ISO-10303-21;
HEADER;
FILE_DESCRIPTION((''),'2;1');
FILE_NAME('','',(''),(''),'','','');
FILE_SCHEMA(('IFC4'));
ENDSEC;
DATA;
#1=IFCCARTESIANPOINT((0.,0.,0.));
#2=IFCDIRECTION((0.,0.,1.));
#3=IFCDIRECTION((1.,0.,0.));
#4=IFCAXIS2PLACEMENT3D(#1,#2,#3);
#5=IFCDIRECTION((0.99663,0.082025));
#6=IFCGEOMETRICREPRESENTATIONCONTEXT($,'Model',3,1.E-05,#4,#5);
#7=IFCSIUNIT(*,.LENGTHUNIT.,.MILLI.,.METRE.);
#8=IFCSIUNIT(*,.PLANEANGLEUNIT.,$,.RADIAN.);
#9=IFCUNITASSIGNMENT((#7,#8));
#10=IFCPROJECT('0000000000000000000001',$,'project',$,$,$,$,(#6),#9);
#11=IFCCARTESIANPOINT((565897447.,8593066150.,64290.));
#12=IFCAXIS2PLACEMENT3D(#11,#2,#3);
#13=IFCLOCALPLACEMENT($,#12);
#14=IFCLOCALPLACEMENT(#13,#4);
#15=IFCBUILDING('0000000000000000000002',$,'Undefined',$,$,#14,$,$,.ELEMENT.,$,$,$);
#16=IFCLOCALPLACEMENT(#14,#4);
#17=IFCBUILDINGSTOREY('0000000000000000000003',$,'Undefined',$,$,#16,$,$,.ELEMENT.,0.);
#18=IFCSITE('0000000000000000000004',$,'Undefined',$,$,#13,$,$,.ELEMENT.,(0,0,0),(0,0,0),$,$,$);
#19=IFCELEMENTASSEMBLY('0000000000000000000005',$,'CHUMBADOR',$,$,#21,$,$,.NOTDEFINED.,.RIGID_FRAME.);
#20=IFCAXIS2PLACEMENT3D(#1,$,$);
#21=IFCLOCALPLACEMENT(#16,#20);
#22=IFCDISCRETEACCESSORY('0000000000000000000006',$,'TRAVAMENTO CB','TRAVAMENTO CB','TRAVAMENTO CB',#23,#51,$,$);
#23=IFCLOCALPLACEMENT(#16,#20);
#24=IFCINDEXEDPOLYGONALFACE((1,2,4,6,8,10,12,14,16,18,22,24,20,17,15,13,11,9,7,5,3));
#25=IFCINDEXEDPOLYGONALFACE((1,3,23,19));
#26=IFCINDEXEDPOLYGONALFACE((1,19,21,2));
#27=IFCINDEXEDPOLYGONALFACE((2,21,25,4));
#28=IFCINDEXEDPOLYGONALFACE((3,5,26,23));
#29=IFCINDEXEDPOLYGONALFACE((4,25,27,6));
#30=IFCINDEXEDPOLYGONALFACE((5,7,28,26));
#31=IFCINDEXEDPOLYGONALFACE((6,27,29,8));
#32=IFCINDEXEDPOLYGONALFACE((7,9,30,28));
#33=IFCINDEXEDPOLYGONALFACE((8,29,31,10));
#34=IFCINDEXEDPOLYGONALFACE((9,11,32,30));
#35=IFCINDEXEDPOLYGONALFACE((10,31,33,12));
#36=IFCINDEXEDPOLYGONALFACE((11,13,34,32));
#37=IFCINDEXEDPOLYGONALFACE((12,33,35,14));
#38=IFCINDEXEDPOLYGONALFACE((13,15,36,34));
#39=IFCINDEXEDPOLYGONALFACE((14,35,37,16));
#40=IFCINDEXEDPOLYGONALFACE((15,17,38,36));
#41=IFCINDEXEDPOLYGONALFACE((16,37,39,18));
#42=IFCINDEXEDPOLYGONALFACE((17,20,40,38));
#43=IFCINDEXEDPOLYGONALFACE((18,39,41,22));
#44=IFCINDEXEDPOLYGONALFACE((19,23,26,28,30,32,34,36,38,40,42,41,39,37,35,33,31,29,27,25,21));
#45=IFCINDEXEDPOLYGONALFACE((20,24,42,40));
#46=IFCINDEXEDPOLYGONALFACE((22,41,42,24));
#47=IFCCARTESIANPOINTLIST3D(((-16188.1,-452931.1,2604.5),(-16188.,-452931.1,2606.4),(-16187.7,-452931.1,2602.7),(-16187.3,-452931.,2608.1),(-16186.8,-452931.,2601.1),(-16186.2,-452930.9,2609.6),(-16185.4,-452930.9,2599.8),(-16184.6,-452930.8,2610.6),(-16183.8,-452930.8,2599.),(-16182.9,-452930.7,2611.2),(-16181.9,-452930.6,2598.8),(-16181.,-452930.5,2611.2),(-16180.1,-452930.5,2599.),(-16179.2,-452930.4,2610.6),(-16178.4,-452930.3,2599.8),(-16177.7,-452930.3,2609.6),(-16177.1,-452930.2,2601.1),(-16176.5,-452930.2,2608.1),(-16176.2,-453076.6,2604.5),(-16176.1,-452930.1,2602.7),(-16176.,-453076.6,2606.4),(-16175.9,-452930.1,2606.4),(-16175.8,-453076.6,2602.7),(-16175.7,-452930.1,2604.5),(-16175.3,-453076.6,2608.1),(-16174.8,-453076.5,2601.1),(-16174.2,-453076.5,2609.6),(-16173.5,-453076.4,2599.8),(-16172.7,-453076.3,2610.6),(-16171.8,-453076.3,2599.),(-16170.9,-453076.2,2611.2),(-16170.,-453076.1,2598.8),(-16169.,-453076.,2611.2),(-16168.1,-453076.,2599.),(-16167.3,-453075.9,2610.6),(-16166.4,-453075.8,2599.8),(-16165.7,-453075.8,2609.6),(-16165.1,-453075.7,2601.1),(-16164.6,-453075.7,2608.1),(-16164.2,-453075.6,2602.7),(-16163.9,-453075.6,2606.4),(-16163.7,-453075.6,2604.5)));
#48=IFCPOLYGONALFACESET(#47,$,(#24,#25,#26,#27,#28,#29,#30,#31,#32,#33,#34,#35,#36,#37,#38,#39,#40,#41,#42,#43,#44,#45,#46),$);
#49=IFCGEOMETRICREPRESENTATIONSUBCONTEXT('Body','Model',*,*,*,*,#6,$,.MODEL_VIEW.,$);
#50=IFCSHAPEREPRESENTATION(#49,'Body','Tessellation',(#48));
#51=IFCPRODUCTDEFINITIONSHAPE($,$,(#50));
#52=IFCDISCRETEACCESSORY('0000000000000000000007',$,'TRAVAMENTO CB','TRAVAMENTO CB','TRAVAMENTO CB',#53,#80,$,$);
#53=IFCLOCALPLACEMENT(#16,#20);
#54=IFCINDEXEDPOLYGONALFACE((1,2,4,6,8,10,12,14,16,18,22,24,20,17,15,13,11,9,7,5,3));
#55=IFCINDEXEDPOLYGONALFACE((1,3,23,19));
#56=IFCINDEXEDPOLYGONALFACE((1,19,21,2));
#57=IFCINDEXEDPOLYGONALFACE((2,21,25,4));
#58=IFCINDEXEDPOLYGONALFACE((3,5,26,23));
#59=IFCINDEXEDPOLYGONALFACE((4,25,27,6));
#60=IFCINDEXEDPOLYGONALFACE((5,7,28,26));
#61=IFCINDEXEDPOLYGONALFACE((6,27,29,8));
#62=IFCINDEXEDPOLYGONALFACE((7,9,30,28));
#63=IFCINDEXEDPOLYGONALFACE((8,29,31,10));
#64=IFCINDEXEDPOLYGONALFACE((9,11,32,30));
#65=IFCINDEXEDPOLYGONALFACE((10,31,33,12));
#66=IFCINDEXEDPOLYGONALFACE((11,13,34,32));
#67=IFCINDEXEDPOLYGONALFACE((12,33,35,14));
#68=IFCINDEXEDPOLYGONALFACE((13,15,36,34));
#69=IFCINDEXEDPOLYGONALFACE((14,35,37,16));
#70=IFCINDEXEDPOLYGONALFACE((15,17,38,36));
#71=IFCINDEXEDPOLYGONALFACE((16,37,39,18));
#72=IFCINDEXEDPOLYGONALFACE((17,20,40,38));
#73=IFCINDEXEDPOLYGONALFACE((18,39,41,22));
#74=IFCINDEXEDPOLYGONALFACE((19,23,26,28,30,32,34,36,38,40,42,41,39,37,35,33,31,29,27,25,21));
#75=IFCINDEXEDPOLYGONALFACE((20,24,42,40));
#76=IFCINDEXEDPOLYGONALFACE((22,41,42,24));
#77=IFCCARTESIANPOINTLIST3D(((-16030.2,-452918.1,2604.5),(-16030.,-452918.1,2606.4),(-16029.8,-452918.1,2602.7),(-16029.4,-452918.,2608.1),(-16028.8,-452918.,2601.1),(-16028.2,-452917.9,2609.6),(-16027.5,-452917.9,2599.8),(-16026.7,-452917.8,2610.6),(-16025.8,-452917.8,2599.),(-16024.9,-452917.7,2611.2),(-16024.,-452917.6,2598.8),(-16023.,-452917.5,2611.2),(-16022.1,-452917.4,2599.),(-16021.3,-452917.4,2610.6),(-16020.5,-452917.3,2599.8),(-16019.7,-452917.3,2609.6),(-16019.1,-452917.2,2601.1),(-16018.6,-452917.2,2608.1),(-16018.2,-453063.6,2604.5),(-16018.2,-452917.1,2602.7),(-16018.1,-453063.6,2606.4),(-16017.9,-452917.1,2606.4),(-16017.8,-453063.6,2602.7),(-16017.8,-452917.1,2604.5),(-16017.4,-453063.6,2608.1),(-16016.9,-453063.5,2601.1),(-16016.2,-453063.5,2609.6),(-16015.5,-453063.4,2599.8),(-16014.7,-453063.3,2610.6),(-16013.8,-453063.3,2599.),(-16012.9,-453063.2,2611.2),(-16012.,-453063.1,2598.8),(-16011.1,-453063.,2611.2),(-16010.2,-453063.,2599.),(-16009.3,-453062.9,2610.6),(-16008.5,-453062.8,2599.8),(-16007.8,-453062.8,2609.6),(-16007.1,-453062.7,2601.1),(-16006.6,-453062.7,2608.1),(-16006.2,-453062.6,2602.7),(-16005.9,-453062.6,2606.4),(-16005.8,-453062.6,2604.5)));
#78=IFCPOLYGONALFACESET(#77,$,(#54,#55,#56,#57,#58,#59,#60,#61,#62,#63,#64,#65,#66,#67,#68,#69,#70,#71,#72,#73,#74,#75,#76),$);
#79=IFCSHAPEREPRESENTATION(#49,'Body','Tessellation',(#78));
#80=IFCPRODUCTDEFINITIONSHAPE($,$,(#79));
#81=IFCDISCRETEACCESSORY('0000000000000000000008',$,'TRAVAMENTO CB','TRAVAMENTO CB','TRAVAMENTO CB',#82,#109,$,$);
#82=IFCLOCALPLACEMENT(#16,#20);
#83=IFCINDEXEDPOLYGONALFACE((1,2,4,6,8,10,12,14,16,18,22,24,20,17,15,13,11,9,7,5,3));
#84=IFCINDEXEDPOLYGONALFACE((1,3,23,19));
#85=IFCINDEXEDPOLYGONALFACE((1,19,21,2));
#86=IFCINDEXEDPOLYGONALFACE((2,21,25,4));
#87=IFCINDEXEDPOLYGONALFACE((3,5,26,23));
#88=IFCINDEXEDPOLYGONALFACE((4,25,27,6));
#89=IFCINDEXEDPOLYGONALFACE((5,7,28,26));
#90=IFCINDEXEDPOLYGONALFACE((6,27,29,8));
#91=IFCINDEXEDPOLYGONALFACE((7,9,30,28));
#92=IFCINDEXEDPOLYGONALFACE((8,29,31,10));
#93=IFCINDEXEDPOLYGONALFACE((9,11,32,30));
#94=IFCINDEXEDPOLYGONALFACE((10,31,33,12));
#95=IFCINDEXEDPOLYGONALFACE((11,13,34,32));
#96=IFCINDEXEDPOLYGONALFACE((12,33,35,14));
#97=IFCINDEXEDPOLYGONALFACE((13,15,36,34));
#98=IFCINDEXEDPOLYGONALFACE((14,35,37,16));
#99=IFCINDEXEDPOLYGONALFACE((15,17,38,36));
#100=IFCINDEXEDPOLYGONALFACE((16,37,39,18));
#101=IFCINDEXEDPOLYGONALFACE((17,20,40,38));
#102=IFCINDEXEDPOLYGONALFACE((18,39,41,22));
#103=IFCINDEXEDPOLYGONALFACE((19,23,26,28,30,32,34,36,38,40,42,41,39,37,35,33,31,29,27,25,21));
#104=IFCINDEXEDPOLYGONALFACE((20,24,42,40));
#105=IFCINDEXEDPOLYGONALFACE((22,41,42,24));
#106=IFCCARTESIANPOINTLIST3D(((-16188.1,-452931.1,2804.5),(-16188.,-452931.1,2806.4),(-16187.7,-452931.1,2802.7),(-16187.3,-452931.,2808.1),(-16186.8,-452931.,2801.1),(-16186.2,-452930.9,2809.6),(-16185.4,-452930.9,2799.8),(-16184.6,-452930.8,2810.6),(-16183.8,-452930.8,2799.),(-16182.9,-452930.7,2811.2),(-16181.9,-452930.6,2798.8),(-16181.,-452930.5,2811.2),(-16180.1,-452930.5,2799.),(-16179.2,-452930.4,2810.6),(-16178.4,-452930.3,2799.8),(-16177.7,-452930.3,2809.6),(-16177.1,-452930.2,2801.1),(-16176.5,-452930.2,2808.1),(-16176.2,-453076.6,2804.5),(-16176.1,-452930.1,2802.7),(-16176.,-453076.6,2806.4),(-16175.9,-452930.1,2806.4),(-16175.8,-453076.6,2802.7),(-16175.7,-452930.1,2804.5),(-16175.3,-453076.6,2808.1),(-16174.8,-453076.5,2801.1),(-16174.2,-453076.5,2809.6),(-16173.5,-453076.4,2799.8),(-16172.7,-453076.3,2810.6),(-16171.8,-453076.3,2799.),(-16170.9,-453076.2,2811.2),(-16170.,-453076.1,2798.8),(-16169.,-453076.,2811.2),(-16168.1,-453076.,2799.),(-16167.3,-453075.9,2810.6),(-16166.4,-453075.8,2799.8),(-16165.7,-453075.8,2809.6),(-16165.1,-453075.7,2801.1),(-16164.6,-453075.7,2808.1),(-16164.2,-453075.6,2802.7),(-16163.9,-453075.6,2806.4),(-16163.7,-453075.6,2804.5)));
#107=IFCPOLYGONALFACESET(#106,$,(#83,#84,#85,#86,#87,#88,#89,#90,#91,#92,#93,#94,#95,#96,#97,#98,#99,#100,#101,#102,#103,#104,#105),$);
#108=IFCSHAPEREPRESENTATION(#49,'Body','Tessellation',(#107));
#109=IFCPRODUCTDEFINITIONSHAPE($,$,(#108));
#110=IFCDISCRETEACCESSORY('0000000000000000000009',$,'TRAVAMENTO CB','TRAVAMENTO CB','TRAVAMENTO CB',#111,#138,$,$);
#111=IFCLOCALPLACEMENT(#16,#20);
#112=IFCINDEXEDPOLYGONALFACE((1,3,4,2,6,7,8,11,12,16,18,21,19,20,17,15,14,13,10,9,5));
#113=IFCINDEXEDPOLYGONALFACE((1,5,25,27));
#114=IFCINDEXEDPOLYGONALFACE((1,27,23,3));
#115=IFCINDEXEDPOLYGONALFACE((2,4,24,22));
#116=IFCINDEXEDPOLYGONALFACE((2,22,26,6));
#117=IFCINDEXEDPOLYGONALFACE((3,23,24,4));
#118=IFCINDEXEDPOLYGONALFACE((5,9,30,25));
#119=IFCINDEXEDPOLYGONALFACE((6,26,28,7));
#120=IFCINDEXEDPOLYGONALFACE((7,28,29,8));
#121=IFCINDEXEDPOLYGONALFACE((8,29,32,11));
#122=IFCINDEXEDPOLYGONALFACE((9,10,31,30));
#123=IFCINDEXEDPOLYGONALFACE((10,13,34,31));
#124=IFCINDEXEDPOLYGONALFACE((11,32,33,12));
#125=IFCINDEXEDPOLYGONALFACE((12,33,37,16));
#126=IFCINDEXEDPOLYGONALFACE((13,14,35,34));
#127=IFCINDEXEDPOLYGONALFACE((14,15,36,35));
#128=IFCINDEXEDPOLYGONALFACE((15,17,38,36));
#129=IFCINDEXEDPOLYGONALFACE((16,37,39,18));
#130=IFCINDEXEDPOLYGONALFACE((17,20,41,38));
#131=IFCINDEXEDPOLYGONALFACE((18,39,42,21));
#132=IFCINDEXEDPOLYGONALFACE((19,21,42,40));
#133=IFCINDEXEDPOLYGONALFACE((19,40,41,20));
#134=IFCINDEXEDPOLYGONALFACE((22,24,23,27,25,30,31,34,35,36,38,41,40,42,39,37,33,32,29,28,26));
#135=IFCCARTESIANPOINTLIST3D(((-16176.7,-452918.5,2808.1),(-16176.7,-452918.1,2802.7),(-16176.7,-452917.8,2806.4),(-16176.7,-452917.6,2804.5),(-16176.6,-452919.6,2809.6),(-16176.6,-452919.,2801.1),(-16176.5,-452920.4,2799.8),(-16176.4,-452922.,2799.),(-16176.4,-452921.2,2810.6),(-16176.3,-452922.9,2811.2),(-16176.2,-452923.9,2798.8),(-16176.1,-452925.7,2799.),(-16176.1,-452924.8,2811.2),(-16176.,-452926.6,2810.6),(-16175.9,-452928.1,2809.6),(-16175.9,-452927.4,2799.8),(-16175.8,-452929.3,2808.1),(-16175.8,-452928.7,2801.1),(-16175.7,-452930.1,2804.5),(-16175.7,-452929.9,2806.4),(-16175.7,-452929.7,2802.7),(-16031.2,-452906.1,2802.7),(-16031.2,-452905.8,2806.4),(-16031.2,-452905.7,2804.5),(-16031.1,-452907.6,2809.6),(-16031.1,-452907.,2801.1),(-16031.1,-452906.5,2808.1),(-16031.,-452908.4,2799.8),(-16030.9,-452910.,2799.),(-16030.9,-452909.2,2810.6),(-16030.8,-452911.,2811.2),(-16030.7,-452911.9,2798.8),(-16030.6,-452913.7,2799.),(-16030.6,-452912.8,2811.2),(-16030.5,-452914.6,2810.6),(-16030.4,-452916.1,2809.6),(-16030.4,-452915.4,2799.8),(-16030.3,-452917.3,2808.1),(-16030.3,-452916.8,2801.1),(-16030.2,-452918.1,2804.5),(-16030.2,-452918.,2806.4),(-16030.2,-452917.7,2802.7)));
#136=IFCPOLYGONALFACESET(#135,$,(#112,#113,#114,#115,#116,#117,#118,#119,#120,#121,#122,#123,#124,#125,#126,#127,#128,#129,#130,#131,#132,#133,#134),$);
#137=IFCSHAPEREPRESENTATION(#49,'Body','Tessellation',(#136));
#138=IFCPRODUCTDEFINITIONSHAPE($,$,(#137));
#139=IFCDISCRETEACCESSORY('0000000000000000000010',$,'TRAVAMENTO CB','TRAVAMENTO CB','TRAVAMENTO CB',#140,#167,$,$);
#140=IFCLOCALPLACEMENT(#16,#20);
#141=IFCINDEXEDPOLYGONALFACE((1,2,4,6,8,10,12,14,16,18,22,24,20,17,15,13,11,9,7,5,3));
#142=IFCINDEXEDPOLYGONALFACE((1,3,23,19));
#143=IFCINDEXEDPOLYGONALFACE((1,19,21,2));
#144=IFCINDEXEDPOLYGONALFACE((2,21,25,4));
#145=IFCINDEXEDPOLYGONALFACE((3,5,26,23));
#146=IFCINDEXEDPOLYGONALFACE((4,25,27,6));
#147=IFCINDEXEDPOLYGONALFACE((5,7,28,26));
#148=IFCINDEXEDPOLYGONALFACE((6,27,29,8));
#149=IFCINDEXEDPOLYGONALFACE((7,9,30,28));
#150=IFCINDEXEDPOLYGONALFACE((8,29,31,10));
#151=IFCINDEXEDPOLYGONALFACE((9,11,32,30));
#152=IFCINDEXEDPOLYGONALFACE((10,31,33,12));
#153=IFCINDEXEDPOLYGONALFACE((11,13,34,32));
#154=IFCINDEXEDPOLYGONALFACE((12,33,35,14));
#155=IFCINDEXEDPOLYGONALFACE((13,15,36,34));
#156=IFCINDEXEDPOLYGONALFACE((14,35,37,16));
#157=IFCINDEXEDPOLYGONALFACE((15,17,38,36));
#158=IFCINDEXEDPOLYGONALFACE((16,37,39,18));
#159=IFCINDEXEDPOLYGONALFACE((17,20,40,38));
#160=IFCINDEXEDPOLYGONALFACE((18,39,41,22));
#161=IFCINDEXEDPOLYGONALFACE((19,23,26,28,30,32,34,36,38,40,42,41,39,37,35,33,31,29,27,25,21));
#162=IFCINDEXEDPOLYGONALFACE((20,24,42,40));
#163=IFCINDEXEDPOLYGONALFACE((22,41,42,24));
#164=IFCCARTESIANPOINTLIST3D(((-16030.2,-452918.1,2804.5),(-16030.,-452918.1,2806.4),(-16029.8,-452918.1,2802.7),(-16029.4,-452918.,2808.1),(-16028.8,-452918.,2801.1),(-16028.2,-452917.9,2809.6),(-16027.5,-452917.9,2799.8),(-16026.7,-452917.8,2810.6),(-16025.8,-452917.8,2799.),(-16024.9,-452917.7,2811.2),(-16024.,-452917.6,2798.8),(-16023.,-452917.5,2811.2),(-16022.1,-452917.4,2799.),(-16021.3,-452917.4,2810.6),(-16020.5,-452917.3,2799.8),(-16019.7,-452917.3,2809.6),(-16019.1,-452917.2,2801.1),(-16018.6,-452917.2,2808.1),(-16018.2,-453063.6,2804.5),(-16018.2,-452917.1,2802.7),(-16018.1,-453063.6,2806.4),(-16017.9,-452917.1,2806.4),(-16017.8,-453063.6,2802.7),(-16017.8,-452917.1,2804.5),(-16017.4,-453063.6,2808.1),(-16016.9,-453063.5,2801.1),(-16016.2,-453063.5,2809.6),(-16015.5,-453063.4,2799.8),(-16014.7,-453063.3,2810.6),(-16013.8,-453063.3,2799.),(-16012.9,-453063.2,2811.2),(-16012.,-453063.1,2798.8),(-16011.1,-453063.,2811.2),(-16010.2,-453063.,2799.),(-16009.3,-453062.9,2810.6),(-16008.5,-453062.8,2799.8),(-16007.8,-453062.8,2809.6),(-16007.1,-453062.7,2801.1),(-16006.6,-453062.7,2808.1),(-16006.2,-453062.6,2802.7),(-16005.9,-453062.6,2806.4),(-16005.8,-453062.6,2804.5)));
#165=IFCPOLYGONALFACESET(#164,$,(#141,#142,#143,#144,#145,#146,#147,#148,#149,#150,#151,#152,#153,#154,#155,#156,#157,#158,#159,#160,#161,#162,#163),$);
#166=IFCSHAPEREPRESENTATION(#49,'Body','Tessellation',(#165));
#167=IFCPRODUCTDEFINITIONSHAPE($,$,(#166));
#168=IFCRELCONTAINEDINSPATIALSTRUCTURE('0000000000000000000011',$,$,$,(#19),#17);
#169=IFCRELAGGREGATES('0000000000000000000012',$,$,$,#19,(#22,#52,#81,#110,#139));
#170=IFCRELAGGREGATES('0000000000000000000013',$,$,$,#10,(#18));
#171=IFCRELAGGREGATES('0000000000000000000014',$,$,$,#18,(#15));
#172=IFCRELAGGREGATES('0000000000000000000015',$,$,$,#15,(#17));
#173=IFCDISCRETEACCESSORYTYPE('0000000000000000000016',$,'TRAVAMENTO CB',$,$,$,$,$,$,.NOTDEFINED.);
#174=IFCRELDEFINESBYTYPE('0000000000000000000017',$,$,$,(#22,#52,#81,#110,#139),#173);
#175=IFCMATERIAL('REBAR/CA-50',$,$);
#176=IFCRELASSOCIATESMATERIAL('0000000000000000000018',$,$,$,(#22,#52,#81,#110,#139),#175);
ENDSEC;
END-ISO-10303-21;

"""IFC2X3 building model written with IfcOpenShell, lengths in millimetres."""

from ifc_helpers import new_model, si_unit, direction, frame, origin_with_axes, origin_2d_with_axis, place, context, subcontext, project, spatial, circle, extrude, material, type_object, element, aggregate, save


model = new_model("IFC2X3")

# Units and contexts
model_context = context("Model", 3, precision=1e-05, world=origin_with_axes(), true_north=direction((0.99663, 0.082025)))
body_context = subcontext(model_context, "Body", "Model", "MODEL_VIEW")
ifc_project = project(units=[si_unit("LENGTHUNIT", "METRE", prefix="MILLI"), si_unit("PLANEANGLEUNIT", "RADIAN")], contexts=[model_context])

# Site, building, storey
site_placement = place(None, frame((565897447.0, 8593066150.0, 64290.0), z_axis=(0.0, 0.0, 1.0), x_axis=(1.0, 0.0, 0.0)))
site = spatial("IfcSite", under=ifc_project, at=site_placement, Name="Undefined", CompositionType="ELEMENT", RefLatitude=(0, 0, 0), RefLongitude=(0, 0, 0))
building_placement = place(site_placement, origin_with_axes())
building = spatial("IfcBuilding", under=site, at=building_placement, Name="Undefined", CompositionType="ELEMENT")
storey_placement = place(building_placement, origin_with_axes())
storey = spatial("IfcBuildingStorey", under=building, at=storey_placement, Name="Undefined", CompositionType="ELEMENT", Elevation=0.0)

# Element assembly, discrete accessories
assembly_1_placement = place(storey_placement, origin_with_axes())
assembly_1 = element("IfcElementAssembly", 1, at=assembly_1_placement, inside=storey, Name="CHUMBADOR", AssemblyPlace="NOTDEFINED", PredefinedType="RIGID_FRAME")
ifc_material_1 = material(Name="REBAR/CA-50")
discrete_accessory_type_1 = type_object("IfcDiscreteAccessoryType", Name="TRAVAMENTO CB")
discrete_accessory_1_placement = place(assembly_1_placement, frame((-16181.9, -452930.6, 2605.0), z_axis=(-0.99663, -0.082025, 0.0), x_axis=(0.082025, -0.99663, 0.0)))
discrete_accessory_1 = element("IfcDiscreteAccessory", 2, at=discrete_accessory_1_placement, type_object=discrete_accessory_type_1, material=ifc_material_1, Name="TRAVAMENTO CB", Description="TRAVAMENTO CB", ObjectType="TRAVAMENTO CB", context=body_context, shape_type="SweptSolid", body=[
    extrude(circle(Radius=6.2, at=origin_2d_with_axis()), frame((146.0, 0.0, 0.0), z_axis=(-1.0, 0.0, 0.0), x_axis=(0.0, -1.0, 0.0)), (0.0, 0.0, 1.0), 146.0),
])
discrete_accessory_2_placement = place(assembly_1_placement, frame((-16012.0, -453063.1, 2605.0), z_axis=(0.99663, 0.082025, 0.0), x_axis=(-0.082025, 0.99663, 0.0)))
discrete_accessory_2 = element("IfcDiscreteAccessory", 3, at=discrete_accessory_2_placement, type_object=discrete_accessory_type_1, material=ifc_material_1, Name="TRAVAMENTO CB", Description="TRAVAMENTO CB", ObjectType="TRAVAMENTO CB", context=body_context, shape_type="SweptSolid", body=[
    extrude(circle(Radius=6.2, at=origin_2d_with_axis()), frame((146.0, 0.0, 0.0), z_axis=(-1.0, 0.0, 0.0), x_axis=(0.0, -1.0, 0.0)), (0.0, 0.0, 1.0), 146.0),
])
discrete_accessory_3_placement = place(assembly_1_placement, frame((-16181.9, -452930.6, 2805.0), z_axis=(-0.99663, -0.082025, 0.0), x_axis=(0.082025, -0.99663, 0.0)))
discrete_accessory_3 = element("IfcDiscreteAccessory", 4, at=discrete_accessory_3_placement, type_object=discrete_accessory_type_1, material=ifc_material_1, Name="TRAVAMENTO CB", Description="TRAVAMENTO CB", ObjectType="TRAVAMENTO CB", context=body_context, shape_type="SweptSolid", body=[
    extrude(circle(Radius=6.2, at=origin_2d_with_axis()), frame((146.0, 0.0, 0.0), z_axis=(-1.0, 0.0, 0.0), x_axis=(0.0, -1.0, 0.0)), (0.0, 0.0, 1.0), 146.0),
])
discrete_accessory_4_placement = place(assembly_1_placement, frame((-16030.7, -452911.9, 2805.0), z_axis=(-0.082025, 0.99663, 0.0), x_axis=(-0.99663, -0.082025, 0.0)))
discrete_accessory_4 = element("IfcDiscreteAccessory", 5, at=discrete_accessory_4_placement, type_object=discrete_accessory_type_1, material=ifc_material_1, Name="TRAVAMENTO CB", Description="TRAVAMENTO CB", ObjectType="TRAVAMENTO CB", context=body_context, shape_type="SweptSolid", body=[
    extrude(circle(Radius=6.2, at=origin_2d_with_axis()), frame((146.0, 0.0, 0.0), z_axis=(-1.0, 0.0, 0.0), x_axis=(0.0, -1.0, 0.0)), (0.0, 0.0, 1.0), 146.0),
])
discrete_accessory_5_placement = place(assembly_1_placement, frame((-16012.0, -453063.1, 2805.0), z_axis=(0.99663, 0.082025, 0.0), x_axis=(-0.082025, 0.99663, 0.0)))
discrete_accessory_5 = element("IfcDiscreteAccessory", 6, at=discrete_accessory_5_placement, type_object=discrete_accessory_type_1, material=ifc_material_1, Name="TRAVAMENTO CB", Description="TRAVAMENTO CB", ObjectType="TRAVAMENTO CB", context=body_context, shape_type="SweptSolid", body=[
    extrude(circle(Radius=6.2, at=origin_2d_with_axis()), frame((146.0, 0.0, 0.0), z_axis=(-1.0, 0.0, 0.0), x_axis=(0.0, -1.0, 0.0)), (0.0, 0.0, 1.0), 146.0),
])
aggregate(assembly_1, [discrete_accessory_1, discrete_accessory_2, discrete_accessory_3, discrete_accessory_4, discrete_accessory_5])

save(model, "model.ifc")
